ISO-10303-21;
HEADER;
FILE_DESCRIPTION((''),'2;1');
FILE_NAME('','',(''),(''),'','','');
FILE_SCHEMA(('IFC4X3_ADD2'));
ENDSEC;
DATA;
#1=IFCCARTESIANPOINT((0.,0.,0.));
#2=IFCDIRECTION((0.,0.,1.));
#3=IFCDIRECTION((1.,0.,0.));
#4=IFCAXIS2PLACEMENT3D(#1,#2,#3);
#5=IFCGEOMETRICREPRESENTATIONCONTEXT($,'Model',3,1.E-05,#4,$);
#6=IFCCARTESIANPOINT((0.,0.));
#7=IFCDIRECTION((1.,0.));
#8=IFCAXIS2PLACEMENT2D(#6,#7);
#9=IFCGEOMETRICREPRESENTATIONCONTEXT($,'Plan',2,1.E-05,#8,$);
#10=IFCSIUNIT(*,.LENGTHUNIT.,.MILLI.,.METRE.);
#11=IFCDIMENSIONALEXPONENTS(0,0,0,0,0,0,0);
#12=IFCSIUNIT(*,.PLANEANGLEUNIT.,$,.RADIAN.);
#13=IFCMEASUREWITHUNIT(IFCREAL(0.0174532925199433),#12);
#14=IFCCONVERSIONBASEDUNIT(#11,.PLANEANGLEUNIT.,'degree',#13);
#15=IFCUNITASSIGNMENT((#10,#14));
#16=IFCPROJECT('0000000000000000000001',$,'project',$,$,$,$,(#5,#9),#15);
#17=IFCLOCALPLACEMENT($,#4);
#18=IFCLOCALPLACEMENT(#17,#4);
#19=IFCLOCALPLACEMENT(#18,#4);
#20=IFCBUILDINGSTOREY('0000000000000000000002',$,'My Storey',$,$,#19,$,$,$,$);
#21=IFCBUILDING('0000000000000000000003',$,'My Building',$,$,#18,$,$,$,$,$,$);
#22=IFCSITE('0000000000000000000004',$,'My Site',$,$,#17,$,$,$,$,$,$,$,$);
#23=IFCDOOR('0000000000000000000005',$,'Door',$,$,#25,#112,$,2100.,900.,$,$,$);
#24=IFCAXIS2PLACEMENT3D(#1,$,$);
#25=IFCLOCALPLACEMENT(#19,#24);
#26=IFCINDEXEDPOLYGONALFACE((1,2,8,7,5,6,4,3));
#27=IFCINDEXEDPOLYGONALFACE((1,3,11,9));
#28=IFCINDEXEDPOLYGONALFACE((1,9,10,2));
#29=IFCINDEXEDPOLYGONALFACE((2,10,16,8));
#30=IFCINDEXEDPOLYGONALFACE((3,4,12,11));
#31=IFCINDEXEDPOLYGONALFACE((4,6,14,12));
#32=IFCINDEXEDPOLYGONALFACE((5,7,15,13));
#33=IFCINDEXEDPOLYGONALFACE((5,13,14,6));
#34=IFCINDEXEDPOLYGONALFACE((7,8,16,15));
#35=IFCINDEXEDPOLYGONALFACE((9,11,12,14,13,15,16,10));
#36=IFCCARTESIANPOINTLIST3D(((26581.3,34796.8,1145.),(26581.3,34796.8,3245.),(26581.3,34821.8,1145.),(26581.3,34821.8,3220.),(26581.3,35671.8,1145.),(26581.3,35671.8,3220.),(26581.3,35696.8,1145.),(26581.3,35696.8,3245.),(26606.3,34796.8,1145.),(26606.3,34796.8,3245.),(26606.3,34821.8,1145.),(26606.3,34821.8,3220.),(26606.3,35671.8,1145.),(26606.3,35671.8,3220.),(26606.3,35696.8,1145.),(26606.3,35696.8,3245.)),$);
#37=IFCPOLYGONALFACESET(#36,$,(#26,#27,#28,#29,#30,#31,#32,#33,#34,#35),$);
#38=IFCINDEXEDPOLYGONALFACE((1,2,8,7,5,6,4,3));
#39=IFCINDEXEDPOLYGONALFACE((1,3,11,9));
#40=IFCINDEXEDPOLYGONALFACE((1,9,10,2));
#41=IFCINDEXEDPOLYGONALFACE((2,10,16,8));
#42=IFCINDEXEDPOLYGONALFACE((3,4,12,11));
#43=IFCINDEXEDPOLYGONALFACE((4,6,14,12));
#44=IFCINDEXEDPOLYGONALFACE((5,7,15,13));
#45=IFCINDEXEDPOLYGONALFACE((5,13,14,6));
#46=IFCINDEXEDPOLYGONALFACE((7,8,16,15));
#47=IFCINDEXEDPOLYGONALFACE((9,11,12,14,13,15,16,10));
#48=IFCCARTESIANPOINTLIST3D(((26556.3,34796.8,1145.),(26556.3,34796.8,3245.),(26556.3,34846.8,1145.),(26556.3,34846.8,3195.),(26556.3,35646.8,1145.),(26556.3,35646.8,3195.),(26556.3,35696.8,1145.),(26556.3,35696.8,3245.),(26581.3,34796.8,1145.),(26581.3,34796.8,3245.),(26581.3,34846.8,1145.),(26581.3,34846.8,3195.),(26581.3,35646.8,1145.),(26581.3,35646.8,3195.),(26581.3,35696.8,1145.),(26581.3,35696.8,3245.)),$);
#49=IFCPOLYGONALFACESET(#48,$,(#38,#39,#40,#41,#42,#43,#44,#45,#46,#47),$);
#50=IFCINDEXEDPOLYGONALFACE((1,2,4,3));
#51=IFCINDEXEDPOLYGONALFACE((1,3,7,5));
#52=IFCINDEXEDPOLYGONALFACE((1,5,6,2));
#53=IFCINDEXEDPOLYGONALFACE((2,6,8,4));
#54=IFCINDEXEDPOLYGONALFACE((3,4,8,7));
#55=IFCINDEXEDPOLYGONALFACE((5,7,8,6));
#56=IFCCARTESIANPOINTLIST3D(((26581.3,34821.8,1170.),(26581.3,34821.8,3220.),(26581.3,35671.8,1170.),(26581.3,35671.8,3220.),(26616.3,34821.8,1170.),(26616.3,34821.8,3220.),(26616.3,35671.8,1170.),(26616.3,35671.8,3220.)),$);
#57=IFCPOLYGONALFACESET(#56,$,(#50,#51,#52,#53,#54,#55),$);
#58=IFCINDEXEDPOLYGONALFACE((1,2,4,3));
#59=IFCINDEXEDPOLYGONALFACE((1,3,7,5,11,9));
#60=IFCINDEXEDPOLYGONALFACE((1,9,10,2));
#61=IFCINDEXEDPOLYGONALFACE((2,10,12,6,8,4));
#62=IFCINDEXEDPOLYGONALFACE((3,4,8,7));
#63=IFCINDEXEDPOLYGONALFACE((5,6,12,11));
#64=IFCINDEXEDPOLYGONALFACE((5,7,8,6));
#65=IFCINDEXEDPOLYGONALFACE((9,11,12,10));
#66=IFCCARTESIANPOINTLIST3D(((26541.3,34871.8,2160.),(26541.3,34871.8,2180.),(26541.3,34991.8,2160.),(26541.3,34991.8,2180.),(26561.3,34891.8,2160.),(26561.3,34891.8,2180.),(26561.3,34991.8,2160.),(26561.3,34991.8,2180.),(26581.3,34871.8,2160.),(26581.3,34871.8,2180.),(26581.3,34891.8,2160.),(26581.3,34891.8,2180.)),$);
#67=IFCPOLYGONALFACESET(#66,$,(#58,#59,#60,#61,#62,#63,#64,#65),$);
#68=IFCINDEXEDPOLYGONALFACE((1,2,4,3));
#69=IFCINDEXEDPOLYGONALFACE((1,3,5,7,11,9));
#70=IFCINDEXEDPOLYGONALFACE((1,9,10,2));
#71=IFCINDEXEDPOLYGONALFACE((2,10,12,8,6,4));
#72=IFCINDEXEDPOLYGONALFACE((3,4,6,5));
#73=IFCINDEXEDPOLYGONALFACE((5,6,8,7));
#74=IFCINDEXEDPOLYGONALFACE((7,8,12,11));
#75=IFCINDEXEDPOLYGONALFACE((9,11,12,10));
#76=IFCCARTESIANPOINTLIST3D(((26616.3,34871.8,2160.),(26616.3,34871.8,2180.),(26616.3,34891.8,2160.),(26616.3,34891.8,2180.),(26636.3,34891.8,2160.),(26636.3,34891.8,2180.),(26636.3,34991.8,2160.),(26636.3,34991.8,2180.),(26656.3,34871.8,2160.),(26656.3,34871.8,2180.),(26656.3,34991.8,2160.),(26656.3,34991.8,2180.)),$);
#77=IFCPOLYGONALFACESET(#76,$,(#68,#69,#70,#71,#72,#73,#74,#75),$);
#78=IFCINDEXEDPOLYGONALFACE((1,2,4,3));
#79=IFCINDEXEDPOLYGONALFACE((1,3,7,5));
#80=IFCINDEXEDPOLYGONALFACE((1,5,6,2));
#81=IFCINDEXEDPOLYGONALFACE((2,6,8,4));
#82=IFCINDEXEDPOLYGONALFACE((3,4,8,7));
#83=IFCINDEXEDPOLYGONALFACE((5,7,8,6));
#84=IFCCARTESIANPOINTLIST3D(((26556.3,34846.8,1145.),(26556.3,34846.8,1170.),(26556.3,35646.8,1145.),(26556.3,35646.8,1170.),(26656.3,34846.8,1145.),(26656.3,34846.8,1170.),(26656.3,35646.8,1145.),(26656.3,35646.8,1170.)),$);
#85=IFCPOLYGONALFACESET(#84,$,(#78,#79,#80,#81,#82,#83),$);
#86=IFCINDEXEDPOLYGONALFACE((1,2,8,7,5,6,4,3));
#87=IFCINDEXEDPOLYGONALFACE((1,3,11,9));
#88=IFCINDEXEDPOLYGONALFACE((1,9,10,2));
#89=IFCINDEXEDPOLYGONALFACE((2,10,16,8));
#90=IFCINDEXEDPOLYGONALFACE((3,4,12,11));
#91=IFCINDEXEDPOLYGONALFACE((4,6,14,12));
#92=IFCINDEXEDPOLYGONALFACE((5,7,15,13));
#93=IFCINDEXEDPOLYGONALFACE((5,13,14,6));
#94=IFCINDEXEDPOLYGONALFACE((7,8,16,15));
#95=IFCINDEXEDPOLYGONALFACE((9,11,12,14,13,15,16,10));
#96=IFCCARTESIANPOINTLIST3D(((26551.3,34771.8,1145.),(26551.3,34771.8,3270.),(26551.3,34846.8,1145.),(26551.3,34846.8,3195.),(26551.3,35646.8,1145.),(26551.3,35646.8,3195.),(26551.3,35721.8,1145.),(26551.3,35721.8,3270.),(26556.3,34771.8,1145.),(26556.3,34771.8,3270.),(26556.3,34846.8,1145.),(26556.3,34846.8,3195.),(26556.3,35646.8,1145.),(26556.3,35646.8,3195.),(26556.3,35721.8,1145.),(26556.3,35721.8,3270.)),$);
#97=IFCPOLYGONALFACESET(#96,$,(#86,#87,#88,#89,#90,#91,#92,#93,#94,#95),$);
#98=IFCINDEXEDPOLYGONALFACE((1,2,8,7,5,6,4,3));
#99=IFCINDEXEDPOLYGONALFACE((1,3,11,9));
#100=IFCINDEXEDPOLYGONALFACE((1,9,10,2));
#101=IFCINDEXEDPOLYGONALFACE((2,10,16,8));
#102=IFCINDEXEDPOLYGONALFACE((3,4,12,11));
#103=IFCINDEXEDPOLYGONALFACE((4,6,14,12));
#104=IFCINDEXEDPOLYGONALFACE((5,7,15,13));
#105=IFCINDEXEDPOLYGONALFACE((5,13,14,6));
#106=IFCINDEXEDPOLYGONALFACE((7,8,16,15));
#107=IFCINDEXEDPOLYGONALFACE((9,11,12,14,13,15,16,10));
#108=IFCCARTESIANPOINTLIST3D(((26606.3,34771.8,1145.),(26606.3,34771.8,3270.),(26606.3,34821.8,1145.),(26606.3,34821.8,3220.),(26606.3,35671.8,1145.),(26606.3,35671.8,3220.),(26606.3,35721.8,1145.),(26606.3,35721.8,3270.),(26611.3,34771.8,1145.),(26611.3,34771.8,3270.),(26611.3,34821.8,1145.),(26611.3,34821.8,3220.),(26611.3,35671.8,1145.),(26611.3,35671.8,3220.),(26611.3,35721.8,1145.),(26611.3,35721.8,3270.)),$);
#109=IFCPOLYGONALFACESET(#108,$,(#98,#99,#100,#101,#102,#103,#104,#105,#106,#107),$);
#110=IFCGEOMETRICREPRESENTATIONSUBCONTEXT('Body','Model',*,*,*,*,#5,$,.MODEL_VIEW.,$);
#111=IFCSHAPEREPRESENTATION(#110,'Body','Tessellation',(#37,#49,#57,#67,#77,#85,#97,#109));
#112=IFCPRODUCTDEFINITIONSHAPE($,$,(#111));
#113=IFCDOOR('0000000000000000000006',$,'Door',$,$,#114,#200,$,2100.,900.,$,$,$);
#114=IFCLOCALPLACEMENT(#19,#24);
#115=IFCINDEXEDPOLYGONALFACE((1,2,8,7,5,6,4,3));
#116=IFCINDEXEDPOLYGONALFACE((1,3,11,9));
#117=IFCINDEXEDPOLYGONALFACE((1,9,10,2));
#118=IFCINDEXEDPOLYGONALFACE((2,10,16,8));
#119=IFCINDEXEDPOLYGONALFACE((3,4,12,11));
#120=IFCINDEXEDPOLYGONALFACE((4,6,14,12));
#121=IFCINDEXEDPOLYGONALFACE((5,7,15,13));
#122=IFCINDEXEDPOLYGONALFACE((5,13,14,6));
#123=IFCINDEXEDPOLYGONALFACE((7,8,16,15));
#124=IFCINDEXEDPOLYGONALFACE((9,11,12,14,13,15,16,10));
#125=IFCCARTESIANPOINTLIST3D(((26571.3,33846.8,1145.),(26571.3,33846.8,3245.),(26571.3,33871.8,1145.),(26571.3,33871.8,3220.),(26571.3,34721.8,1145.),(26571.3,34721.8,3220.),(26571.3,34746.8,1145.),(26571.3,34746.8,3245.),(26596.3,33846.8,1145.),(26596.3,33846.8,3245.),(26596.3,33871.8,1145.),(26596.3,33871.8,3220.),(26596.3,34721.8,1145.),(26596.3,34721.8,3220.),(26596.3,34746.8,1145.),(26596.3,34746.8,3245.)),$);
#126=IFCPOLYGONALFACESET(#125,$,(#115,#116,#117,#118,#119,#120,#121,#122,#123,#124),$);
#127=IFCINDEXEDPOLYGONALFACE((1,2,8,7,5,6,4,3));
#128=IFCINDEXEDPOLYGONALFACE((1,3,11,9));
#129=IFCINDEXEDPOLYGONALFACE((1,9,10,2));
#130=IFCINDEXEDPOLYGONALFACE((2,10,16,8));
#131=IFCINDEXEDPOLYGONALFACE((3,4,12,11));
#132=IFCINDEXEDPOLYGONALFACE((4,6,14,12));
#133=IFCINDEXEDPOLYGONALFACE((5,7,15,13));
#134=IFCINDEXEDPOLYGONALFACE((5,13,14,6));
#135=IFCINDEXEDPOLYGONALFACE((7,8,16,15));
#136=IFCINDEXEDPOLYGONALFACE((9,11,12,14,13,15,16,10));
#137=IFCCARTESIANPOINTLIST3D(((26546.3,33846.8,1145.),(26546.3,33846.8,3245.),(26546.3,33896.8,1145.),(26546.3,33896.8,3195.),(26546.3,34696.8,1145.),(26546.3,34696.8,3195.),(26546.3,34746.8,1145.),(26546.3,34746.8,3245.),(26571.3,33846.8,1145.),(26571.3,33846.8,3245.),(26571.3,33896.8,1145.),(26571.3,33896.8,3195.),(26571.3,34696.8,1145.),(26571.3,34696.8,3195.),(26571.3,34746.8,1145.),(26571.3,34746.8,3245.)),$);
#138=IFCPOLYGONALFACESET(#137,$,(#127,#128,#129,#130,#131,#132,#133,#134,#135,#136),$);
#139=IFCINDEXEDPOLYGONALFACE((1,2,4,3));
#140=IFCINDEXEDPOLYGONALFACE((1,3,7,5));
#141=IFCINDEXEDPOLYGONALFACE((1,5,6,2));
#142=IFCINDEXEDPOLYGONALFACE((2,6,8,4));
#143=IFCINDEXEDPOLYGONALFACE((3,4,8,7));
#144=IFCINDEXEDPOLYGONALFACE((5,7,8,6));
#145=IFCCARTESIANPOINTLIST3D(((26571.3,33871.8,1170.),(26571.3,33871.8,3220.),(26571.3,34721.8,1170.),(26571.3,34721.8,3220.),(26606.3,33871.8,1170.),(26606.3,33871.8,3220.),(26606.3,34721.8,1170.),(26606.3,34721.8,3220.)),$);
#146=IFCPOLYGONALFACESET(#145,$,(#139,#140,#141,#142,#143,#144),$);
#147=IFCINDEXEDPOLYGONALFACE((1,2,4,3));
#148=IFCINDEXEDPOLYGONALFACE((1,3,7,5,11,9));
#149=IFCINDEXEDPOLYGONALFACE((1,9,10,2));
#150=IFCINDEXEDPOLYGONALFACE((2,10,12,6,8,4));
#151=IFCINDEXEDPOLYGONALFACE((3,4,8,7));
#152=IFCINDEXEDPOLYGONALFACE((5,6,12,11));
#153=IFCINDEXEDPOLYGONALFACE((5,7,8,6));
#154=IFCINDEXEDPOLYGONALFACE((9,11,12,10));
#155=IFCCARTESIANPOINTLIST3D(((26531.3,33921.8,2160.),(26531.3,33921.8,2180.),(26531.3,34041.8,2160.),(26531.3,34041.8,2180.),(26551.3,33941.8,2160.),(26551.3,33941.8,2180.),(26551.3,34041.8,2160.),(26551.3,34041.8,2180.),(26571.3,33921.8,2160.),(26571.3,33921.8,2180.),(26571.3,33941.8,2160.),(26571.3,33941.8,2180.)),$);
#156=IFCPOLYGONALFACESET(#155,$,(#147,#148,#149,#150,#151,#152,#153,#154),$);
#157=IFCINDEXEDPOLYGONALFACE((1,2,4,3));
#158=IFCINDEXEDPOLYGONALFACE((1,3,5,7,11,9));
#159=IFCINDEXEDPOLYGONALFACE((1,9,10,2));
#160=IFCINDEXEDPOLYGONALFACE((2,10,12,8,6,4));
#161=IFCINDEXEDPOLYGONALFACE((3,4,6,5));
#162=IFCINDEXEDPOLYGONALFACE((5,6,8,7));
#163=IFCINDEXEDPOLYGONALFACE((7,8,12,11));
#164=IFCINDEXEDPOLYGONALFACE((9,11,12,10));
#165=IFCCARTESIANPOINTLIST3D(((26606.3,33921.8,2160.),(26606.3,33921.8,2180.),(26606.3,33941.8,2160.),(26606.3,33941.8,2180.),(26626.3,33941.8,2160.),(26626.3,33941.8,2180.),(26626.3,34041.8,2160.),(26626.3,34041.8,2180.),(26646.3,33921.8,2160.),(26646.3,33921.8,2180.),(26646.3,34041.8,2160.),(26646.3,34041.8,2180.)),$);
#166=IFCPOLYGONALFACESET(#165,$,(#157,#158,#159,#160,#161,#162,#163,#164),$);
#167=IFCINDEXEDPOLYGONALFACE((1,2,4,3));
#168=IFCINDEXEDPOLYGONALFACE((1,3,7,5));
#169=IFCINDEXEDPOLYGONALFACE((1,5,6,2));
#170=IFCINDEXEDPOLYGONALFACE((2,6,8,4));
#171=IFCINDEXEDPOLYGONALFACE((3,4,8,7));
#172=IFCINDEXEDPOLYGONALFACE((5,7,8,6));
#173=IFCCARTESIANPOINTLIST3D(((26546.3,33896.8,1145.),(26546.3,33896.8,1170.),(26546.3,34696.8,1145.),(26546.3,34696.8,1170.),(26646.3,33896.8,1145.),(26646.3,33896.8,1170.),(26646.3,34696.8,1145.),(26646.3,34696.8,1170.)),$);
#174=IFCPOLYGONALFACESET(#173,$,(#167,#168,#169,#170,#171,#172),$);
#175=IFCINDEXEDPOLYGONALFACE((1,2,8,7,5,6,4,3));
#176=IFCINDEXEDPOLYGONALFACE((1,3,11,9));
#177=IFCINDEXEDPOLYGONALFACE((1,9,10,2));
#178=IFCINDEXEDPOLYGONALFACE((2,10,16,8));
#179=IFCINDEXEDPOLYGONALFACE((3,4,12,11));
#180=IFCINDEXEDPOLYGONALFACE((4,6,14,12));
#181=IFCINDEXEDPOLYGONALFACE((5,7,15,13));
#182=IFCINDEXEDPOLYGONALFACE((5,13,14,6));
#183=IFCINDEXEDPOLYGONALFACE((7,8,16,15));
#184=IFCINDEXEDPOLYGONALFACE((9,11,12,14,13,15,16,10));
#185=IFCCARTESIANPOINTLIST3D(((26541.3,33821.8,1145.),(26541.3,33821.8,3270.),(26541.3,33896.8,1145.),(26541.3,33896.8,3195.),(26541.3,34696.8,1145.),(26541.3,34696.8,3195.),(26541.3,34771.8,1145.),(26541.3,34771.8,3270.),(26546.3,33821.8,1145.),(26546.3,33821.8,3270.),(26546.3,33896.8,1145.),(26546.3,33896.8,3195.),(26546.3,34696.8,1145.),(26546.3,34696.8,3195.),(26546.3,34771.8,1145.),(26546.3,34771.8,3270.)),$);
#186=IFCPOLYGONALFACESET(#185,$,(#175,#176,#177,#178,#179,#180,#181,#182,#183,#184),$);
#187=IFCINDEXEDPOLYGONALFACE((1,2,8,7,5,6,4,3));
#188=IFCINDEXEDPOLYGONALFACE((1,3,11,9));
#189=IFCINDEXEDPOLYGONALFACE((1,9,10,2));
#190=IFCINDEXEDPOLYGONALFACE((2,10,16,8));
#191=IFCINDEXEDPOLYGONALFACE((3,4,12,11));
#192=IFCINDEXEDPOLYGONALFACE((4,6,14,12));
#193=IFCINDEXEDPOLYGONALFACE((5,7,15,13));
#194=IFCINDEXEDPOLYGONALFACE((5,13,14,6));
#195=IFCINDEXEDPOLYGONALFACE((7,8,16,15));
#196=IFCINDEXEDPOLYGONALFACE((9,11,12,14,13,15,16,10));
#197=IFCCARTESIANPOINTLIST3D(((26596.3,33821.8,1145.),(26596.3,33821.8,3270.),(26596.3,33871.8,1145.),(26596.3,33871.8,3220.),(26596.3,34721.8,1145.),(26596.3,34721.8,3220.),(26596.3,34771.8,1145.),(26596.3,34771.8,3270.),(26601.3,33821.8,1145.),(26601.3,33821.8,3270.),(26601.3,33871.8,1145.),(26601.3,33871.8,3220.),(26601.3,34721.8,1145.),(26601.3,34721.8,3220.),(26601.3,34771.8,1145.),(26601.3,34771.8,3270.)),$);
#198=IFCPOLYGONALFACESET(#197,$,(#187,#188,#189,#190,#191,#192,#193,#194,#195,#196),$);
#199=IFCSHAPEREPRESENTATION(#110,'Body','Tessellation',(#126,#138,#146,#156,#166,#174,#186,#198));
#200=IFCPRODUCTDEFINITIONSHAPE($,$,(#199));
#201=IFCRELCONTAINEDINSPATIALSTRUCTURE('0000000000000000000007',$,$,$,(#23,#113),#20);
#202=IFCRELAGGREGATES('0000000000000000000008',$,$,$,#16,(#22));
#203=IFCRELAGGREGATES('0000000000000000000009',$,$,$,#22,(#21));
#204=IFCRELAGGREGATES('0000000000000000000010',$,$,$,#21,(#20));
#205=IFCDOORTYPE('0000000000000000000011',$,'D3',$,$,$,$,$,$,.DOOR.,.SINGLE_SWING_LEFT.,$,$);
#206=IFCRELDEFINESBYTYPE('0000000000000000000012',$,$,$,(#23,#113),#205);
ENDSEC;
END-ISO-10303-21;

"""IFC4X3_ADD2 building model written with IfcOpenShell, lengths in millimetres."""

from ifc_helpers import new_model, entity, si_unit, converted_unit, frame, origin_with_axes, origin_2d_with_axis, place, context, subcontext, project, spatial, line, indexed_curve, outline, extrude, shape, source, transform, mapped, type_object, type_shapes, element, save


model = new_model("IFC4X3_ADD2")

# Units and contexts
model_context = context("Model", 3, precision=1e-05, world=origin_with_axes())
plan_context = context("Plan", 2, precision=1e-05, world=origin_2d_with_axis())
body_context_1 = subcontext(model_context, "Body", "Model", "MODEL_VIEW")
body_context_2 = subcontext(plan_context, "Body", "Plan", "PLAN_VIEW")
ifc_project = project(units=[si_unit("LENGTHUNIT", "METRE", prefix="MILLI"), converted_unit("PLANEANGLEUNIT", "degree", entity("IfcReal", 0.0174532925199433), si_unit("PLANEANGLEUNIT", "RADIAN"), dimensions=[0, 0, 0, 0, 0, 0, 0])], contexts=[model_context, plan_context])

# Site, building, storey
site_placement = place(None, origin_with_axes())
site = spatial("IfcSite", under=ifc_project, at=site_placement, Name="My Site")
building_placement = place(site_placement, origin_with_axes())
building = spatial("IfcBuilding", under=site, at=building_placement, Name="My Building")
storey_placement = place(building_placement, origin_with_axes())
storey = spatial("IfcBuildingStorey", under=building, at=storey_placement, Name="My Storey")

# Doors
door_type = type_object("IfcDoorType", Name="D3", OperationType="SINGLE_SWING_LEFT", PredefinedType="DOOR")
shared_shape_1 = source(origin_with_axes(), body_context_1, "Body", "SweptSolid", [
    extrude(outline(indexed_curve([(0.0, 0.0), (0.0, 2100.0), (900.0, 2100.0), (900.0, 0.0), (875.0, 0.0), (875.0, 2075.0), (25.0, 2075.0), (25.0, 0.0)], segments=[line(1, 2, 3, 4, 5, 6, 7, 8, 1)])), frame((0.0, 25.0, 0.0), z_axis=(0.0, -1.0, 0.0), x_axis=(1.0, 0.0, 0.0)), (0.0, 0.0, -1.0), 25.0),
    extrude(outline(indexed_curve([(0.0, 0.0), (0.0, 2100.0), (900.0, 2100.0), (900.0, 0.0), (850.0, 0.0), (850.0, 2050.0), (50.0, 2050.0), (50.0, 0.0)], segments=[line(1, 2, 3, 4, 5, 6, 7, 8, 1)])), frame((0.0, 0.0, 0.0), z_axis=(0.0, -1.0, 0.0), x_axis=(1.0, 0.0, 0.0)), (0.0, 0.0, -1.0), 25.0),
    extrude(outline(indexed_curve([(0.0, 0.0), (850.0, 0.0), (850.0, 35.0), (0.0, 35.0)], segments=[line(1, 2, 3, 4, 1)])), frame((25.0, 25.0, 25.0), z_axis=(0.0, 0.0, 1.0), x_axis=(1.0, 0.0, 0.0)), (0.0, 0.0, 1.0), 2050.0),
    extrude(outline(indexed_curve([(0.0, 0.0), (0.0, -40.0), (-120.0, -40.0), (-120.0, -20.0), (-20.0, -20.0), (-20.0, 0.0)], segments=[line(1, 2, 3, 4, 5, 6, 1)])), frame((825.0, 25.0, 1015.0), z_axis=(0.0, 0.0, 1.0), x_axis=(1.0, 0.0, 0.0)), (0.0, 0.0, 1.0), 20.0),
    extrude(outline(indexed_curve([(0.0, 0.0), (0.0, 40.0), (-120.0, 40.0), (-120.0, 20.0), (-20.0, 20.0), (-20.0, 0.0)], segments=[line(1, 2, 3, 4, 5, 6, 1)])), frame((825.0, 60.0, 1015.0), z_axis=(0.0, 0.0, 1.0), x_axis=(1.0, 0.0, 0.0)), (0.0, 0.0, 1.0), 20.0),
    extrude(outline(indexed_curve([(0.0, 0.0), (800.0, 0.0), (800.0, 100.0), (0.0, 100.0)], segments=[line(1, 2, 3, 4, 1)])), frame((50.0, 0.0, 0.0), z_axis=(0.0, 0.0, 1.0), x_axis=(1.0, 0.0, 0.0)), (0.0, 0.0, 1.0), 25.0),
    extrude(outline(indexed_curve([(0.0, 0.0), (0.0, 2125.0), (950.0, 2125.0), (950.0, 0.0), (875.0, 0.0), (875.0, 2050.0), (75.0, 2050.0), (75.0, 0.0)], segments=[line(1, 2, 3, 4, 5, 6, 7, 8, 1)])), frame((-25.0, -5.0, 0.0), z_axis=(0.0, -1.0, 0.0), x_axis=(1.0, 0.0, 0.0)), (0.0, 0.0, -1.0), 5.0),
    extrude(outline(indexed_curve([(0.0, 0.0), (0.0, 2125.0), (950.0, 2125.0), (950.0, 0.0), (900.0, 0.0), (900.0, 2075.0), (50.0, 2075.0), (50.0, 0.0)], segments=[line(1, 2, 3, 4, 5, 6, 7, 8, 1)])), frame((-25.0, 50.0, 0.0), z_axis=(0.0, -1.0, 0.0), x_axis=(1.0, 0.0, 0.0)), (0.0, 0.0, -1.0), 5.0),
])
shared_shape_2 = source(origin_with_axes(), body_context_2, "Body", "Curve2D", [
    entity("IfcIndexedPolyCurve", entity("IfcCartesianPointList2D", [[0.0, 0.0], [0.0, 50.0], [25.0, 50.0], [25.0, 25.0], [50.0, 25.0], [50.0, 0.0]]), [entity("IfcLineIndex", [1, 2, 3, 4, 5, 6, 1])]),
    entity("IfcIndexedPolyCurve", entity("IfcCartesianPointList2D", [[900.0, 0.0], [900.0, 50.0], [875.0, 50.0], [875.0, 25.0], [850.0, 25.0], [850.0, 0.0]]), [entity("IfcLineIndex", [1, 2, 3, 4, 5, 6, 1])]),
    entity("IfcTrimmedCurve", entity("IfcEllipse", entity("IfcAxis2Placement2D", entity("IfcCartesianPoint", [60.0, 50.0]), entity("IfcDirection", [1.0, 0.0])), 815.0, 850.0), [entity("IfcCartesianPoint", [875.0, 50.0])], [entity("IfcCartesianPoint", [60.0, 900.0])], True, "CARTESIAN"),
    entity("IfcIndexedPolyCurve", entity("IfcCartesianPointList2D", [[25.0, 50.0], [60.0, 50.0], [60.0, 900.0], [25.0, 900.0]]), [entity("IfcLineIndex", [1, 2, 3, 4, 1])]),
])
type_shapes(door_type, [shared_shape_1, shared_shape_2])
for number, where, z_axis, x_axis, name in (
    (1, (26556.3, 35696.8, 1145.0), (0.0, 0.0, 1.0), (0.0, -1.0, 0.0), "Door"),
    (2, (26546.3, 34746.8, 1145.0), (0.0, 0.0, 1.0), (0.0, -1.0, 0.0), "Door"),
):
    element("IfcDoor", number, at=place(storey_placement, frame(where, z_axis=z_axis, x_axis=x_axis)), inside=storey, type_object=door_type, Name=name, OverallHeight=2100.0, OverallWidth=900.0, shapes=[
        shape(body_context_1, "Body", "MappedRepresentation", [mapped(shared_shape_1, transform((0.0, 0.0, 0.0), x_axis=(1.0, 0.0, 0.0), y_axis=(0.0, 1.0, 0.0), z_axis=(0.0, 0.0, 1.0), scale=1.0))]),
        shape(body_context_2, "Body", "MappedRepresentation", [mapped(shared_shape_2, transform((0.0, 0.0, 0.0), x_axis=(1.0, 0.0, 0.0), y_axis=(0.0, 1.0, 0.0), z_axis=(0.0, 0.0, 1.0), scale=1.0))]),
    ])

save(model, "model.ifc")
